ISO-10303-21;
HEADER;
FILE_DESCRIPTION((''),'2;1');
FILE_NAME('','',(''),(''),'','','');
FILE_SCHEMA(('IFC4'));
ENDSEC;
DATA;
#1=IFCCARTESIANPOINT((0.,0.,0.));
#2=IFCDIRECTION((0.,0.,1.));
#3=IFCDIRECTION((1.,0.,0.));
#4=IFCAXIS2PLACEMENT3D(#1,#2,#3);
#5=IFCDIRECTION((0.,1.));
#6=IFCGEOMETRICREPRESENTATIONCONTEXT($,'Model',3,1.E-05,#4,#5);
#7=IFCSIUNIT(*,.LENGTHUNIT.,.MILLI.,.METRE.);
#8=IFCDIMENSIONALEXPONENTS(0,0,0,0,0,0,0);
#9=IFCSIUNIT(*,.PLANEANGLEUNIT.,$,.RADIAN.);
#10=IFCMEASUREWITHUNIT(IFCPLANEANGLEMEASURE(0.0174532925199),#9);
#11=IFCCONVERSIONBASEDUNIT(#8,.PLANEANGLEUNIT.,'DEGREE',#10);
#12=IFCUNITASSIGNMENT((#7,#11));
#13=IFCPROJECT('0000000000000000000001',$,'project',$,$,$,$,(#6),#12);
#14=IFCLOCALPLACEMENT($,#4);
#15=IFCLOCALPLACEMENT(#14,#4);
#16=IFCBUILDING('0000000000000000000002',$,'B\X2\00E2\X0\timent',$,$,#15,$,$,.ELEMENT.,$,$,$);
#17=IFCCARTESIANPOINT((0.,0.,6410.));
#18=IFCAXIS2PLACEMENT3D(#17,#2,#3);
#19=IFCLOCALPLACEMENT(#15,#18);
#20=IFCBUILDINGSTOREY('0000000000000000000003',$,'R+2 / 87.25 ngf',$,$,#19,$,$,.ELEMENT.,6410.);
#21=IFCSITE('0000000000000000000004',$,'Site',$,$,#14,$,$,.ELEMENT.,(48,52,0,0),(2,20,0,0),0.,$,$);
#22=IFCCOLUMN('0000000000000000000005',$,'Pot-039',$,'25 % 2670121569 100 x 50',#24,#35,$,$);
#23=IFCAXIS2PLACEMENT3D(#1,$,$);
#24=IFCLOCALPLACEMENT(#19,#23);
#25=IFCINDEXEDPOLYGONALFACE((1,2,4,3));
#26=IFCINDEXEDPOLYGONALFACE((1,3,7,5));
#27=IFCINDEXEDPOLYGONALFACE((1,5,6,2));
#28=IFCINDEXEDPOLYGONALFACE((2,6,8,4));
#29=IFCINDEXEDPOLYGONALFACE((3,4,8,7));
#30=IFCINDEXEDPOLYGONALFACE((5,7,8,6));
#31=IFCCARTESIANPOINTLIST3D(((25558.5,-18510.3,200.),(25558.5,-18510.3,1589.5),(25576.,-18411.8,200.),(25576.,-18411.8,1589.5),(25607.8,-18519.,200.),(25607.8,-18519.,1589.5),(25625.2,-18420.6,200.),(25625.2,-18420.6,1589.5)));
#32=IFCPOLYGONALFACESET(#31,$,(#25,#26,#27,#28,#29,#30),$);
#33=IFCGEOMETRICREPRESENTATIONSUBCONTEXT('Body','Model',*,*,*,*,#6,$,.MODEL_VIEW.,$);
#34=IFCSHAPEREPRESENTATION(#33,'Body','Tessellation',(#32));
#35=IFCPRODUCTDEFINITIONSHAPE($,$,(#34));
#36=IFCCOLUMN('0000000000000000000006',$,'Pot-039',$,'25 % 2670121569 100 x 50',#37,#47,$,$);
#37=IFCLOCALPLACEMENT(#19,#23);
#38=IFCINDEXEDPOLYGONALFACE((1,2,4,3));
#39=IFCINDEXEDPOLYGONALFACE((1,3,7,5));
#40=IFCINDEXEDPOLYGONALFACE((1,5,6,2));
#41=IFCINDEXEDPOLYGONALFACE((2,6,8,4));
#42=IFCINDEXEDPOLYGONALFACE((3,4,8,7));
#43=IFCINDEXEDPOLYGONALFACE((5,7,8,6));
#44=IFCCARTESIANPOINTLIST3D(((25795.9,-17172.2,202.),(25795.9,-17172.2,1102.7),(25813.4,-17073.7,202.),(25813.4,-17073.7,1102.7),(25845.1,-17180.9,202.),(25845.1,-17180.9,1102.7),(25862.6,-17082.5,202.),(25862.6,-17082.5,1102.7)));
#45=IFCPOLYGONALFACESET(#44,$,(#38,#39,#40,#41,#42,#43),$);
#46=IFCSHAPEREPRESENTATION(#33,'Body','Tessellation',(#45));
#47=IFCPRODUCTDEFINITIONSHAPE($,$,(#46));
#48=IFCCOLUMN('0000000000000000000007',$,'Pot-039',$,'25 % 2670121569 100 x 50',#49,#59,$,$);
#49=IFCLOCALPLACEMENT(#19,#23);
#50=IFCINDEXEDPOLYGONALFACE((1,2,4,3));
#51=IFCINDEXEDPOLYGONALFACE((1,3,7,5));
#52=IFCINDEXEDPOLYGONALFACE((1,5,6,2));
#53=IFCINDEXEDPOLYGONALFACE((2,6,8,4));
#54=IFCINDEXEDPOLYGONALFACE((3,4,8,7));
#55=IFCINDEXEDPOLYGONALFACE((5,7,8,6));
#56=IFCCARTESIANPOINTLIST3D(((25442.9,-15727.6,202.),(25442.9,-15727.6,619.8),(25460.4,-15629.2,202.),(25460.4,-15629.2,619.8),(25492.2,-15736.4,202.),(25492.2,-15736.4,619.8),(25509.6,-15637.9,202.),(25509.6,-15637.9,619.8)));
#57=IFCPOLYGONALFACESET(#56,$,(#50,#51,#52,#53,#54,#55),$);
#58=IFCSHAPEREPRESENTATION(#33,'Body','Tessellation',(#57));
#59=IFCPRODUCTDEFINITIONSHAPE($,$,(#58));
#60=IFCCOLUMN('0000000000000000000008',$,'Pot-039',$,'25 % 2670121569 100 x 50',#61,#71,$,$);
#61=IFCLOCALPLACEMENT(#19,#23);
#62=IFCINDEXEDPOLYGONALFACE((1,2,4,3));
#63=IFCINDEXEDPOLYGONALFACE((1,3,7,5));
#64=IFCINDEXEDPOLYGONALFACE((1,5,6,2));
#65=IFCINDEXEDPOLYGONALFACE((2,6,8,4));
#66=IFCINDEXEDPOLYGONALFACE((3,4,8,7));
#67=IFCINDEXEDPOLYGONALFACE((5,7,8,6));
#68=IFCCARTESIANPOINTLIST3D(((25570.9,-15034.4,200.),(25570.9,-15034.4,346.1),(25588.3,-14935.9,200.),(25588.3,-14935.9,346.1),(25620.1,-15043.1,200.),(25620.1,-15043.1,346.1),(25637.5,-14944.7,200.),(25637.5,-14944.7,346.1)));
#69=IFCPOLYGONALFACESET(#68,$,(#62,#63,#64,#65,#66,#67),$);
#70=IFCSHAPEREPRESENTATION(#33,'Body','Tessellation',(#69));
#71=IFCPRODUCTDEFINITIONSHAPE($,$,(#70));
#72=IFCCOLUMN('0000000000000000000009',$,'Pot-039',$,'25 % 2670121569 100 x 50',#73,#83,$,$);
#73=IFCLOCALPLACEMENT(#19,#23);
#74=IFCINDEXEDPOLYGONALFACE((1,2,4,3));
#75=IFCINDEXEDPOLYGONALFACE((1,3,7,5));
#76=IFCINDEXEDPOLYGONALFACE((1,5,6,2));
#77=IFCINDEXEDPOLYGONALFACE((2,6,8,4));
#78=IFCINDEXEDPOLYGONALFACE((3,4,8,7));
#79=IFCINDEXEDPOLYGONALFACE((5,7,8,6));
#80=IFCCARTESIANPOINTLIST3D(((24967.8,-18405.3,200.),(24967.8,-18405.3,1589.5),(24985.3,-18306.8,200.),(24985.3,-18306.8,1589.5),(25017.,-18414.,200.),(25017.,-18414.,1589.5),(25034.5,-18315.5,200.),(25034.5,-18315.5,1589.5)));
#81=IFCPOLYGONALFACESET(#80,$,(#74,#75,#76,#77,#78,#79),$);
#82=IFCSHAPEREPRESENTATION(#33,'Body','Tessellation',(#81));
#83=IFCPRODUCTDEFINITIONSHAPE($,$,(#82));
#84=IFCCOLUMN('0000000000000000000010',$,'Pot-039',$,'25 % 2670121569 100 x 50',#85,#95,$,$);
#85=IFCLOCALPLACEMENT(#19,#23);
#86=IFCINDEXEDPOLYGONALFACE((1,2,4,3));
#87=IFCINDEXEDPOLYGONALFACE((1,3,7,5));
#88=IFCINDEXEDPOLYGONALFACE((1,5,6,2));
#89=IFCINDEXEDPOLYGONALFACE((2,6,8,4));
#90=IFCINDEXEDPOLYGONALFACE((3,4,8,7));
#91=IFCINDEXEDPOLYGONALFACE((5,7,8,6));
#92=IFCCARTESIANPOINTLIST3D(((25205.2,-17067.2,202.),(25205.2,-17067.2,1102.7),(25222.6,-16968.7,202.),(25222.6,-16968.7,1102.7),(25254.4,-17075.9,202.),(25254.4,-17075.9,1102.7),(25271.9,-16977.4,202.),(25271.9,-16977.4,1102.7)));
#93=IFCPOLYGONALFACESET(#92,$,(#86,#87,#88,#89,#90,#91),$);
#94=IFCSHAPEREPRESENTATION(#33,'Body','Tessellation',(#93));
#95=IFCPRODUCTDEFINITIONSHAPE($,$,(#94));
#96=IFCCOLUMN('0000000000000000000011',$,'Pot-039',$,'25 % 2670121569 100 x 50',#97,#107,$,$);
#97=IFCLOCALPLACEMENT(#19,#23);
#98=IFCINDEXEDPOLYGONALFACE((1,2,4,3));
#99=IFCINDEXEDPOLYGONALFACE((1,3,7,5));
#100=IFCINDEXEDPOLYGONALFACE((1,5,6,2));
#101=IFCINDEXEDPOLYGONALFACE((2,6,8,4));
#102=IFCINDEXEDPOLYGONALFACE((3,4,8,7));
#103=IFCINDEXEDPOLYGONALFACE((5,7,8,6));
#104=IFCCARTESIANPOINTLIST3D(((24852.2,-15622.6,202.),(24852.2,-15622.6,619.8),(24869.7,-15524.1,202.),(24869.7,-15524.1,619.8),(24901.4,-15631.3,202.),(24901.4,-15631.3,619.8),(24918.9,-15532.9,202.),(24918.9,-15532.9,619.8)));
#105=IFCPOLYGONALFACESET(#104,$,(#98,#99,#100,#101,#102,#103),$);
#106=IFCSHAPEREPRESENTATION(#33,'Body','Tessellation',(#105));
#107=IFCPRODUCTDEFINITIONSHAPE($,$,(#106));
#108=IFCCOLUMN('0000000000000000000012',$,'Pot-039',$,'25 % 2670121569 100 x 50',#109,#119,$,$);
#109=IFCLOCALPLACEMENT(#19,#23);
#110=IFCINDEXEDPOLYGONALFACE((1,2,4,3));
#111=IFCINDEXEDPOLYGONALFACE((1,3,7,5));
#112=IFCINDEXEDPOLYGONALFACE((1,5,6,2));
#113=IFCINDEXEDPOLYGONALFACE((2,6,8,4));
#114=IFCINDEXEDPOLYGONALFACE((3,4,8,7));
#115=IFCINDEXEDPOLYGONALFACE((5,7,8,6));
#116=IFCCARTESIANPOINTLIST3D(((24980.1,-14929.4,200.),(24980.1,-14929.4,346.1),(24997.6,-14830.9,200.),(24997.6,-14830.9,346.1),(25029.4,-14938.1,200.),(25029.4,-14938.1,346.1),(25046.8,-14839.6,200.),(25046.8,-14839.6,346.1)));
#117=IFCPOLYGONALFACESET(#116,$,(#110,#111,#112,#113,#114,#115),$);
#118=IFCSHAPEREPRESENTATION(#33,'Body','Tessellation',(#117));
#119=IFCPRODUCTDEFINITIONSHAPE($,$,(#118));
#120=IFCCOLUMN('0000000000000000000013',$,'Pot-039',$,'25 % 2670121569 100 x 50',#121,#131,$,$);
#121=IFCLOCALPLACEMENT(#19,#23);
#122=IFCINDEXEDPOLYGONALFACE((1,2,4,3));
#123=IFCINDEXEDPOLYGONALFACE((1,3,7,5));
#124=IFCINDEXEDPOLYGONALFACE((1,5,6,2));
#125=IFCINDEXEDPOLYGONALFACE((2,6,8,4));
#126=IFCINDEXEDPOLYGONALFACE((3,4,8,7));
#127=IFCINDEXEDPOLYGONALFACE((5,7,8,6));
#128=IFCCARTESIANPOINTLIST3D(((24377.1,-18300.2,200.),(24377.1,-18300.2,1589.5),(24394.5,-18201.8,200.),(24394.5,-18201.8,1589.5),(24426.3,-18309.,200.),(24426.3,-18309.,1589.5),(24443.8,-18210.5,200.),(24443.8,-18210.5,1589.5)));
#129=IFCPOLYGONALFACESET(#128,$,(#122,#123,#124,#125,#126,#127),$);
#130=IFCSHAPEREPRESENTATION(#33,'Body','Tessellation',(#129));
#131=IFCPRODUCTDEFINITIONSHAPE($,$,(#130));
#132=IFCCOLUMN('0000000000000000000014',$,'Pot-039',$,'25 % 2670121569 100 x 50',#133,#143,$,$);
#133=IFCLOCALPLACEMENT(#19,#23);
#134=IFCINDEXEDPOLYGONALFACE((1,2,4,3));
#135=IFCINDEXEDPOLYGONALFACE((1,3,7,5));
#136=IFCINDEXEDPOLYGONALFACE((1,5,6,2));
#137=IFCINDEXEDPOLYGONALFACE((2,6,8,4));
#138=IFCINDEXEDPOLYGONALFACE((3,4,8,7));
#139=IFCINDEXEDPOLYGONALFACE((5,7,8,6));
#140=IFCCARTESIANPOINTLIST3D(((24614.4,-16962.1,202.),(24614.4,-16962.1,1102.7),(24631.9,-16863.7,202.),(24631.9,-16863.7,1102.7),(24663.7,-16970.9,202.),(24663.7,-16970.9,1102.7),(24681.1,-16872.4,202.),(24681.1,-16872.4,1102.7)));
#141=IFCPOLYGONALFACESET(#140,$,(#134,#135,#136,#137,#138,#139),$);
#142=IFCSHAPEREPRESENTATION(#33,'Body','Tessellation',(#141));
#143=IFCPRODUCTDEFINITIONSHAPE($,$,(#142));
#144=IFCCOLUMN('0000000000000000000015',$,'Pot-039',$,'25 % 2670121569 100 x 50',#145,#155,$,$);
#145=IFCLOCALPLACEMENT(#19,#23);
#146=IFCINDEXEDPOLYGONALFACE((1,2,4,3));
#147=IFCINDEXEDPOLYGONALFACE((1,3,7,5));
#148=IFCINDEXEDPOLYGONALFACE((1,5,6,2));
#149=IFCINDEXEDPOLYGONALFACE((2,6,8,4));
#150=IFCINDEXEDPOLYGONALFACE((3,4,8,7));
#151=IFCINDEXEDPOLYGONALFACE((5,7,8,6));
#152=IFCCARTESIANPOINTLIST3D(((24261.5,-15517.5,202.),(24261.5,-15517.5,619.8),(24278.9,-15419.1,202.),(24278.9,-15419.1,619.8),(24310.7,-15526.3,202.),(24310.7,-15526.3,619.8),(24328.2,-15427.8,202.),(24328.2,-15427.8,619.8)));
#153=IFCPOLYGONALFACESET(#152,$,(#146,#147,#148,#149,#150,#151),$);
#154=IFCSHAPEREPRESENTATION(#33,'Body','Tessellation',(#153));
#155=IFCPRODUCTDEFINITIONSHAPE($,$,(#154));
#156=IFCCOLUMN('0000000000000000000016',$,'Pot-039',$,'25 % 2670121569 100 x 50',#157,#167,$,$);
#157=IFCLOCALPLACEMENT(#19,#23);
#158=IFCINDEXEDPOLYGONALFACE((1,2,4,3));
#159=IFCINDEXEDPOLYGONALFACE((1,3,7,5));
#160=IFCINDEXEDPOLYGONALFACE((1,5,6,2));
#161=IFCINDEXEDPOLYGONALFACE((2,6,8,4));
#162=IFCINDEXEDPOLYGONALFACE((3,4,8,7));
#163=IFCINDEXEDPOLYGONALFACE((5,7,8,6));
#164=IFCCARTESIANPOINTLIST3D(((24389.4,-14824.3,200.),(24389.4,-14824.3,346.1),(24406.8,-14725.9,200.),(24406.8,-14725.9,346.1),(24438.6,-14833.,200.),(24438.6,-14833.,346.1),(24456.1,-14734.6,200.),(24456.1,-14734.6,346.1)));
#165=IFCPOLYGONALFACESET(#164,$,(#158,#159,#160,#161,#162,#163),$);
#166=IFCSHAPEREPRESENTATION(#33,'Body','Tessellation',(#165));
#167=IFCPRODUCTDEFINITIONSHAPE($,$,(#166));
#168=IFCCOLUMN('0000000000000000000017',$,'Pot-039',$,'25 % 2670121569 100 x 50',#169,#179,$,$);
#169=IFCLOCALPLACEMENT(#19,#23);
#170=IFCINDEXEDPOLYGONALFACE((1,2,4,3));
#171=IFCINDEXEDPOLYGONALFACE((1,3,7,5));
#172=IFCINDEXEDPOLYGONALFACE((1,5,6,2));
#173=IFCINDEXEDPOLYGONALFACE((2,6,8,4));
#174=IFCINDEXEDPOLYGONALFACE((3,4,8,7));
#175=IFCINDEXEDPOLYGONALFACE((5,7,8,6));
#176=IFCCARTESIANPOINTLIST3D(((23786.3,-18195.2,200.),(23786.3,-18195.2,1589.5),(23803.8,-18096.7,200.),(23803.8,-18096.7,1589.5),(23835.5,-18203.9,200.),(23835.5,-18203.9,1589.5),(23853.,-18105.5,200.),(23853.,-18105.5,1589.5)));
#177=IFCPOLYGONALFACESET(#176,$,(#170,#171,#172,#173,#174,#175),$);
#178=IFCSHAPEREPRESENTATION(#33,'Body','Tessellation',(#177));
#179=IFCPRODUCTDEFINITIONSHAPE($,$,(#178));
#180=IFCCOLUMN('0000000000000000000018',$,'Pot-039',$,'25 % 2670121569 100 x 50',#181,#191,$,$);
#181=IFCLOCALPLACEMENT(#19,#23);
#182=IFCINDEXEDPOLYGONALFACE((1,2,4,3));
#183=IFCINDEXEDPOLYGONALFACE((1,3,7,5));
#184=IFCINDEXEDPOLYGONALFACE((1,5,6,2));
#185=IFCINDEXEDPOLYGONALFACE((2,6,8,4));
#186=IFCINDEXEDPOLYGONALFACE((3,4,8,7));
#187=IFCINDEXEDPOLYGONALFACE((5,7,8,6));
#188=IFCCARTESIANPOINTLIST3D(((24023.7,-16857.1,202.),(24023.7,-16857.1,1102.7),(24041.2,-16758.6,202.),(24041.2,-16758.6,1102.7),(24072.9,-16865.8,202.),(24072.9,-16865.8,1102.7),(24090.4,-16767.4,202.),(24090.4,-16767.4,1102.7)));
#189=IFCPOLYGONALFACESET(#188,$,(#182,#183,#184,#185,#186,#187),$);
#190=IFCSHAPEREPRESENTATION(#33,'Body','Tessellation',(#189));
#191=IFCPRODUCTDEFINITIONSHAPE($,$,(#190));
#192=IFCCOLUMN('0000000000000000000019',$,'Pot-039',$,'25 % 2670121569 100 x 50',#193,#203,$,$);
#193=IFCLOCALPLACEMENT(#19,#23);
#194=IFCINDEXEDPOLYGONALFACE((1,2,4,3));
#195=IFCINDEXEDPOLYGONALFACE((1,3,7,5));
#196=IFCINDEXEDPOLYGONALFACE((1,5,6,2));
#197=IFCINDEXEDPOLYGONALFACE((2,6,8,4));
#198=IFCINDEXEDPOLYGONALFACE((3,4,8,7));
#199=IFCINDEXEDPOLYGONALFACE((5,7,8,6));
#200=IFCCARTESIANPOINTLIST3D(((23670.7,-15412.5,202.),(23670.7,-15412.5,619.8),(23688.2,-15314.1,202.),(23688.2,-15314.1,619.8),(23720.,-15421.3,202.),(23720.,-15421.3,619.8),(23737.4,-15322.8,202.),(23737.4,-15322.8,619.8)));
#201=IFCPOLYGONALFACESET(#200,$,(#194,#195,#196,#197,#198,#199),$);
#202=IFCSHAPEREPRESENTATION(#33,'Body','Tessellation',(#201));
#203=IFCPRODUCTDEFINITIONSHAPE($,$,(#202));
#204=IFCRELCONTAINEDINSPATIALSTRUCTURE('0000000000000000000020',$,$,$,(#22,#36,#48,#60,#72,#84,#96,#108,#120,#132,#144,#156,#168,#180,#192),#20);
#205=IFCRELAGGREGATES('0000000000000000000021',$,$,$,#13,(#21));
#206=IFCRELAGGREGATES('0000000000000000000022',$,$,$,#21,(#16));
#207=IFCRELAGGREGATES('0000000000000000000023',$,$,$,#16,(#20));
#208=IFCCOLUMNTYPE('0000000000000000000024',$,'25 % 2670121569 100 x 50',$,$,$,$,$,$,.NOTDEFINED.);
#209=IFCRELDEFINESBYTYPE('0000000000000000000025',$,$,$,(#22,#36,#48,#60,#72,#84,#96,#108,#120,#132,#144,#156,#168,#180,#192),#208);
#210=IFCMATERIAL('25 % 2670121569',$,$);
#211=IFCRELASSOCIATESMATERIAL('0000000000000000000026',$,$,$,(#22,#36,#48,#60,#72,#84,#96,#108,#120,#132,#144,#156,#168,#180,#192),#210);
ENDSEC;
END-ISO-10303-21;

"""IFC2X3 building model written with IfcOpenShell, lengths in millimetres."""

from ifc_helpers import new_model, entity, si_unit, converted_unit, direction, frame, origin_with_axes, origin_2d_with_axis, place, context, subcontext, project, spatial, rectangle, extrude, material, type_object, element, save


model = new_model("IFC2X3")

# Units and contexts
model_context = context("Model", 3, precision=1e-05, world=origin_with_axes(), true_north=direction((0.0, 1.0)))
body_context = subcontext(model_context, "Body", "Model", "MODEL_VIEW")
ifc_project = project(units=[si_unit("LENGTHUNIT", "METRE", prefix="MILLI"), converted_unit("PLANEANGLEUNIT", "DEGREE", entity("IfcPlaneAngleMeasure", 0.0174532925199), si_unit("PLANEANGLEUNIT", "RADIAN"), dimensions=[0, 0, 0, 0, 0, 0, 0])], contexts=[model_context])

# Site, building, storey
site_placement = place(None, origin_with_axes())
site = spatial("IfcSite", under=ifc_project, at=site_placement, Name="Site", CompositionType="ELEMENT", RefLatitude=(48, 52, 0, 0), RefLongitude=(2, 20, 0, 0), RefElevation=0.0)
building_placement = place(site_placement, origin_with_axes())
building = spatial("IfcBuilding", under=site, at=building_placement, Name="Bâtiment", CompositionType="ELEMENT")
storey_placement = place(building_placement, frame((0.0, 0.0, 6410.0), z_axis=(0.0, 0.0, 1.0), x_axis=(1.0, 0.0, 0.0)))
storey = spatial("IfcBuildingStorey", under=building, at=storey_placement, Name="R+2 / 87.25 ngf", CompositionType="ELEMENT", Elevation=6410.0)

# Columns
ifc_material = material(Name="25 % 2670121569")
column_type = type_object("IfcColumnType", Name="25 % 2670121569 100 x 50", PredefinedType="NOTDEFINED")
column_1_placement = place(storey_placement, frame((25591.9, -18465.4, 200.0), z_axis=(0.0, 0.0, 1.0), x_axis=(0.17478, 0.984607, 0.0)))
element("IfcColumn", 1, at=column_1_placement, inside=storey, type_object=column_type, material=ifc_material, Name="Pot-039", ObjectType="25 % 2670121569 100 x 50", context=body_context, shape_type="SweptSolid", body=[
    extrude(rectangle(XDim=100.0, YDim=50.0, at=origin_2d_with_axis()), origin_with_axes(), (0.0, 0.0, 1.0), 1389.5),
])
column_2_placement = place(storey_placement, frame((25829.2, -17127.3, 202.0), z_axis=(0.0, 0.0, 1.0), x_axis=(0.17478, 0.984607, 0.0)))
element("IfcColumn", 2, at=column_2_placement, inside=storey, type_object=column_type, material=ifc_material, Name="Pot-039", ObjectType="25 % 2670121569 100 x 50", context=body_context, shape_type="SweptSolid", body=[
    extrude(rectangle(XDim=100.0, YDim=50.0, at=origin_2d_with_axis()), origin_with_axes(), (0.0, 0.0, 1.0), 900.7),
])
column_3_placement = place(storey_placement, frame((25476.3, -15682.8, 202.0), z_axis=(0.0, 0.0, 1.0), x_axis=(0.17478, 0.984607, 0.0)))
element("IfcColumn", 3, at=column_3_placement, inside=storey, type_object=column_type, material=ifc_material, Name="Pot-039", ObjectType="25 % 2670121569 100 x 50", context=body_context, shape_type="SweptSolid", body=[
    extrude(rectangle(XDim=100.0, YDim=50.0, at=origin_2d_with_axis()), origin_with_axes(), (0.0, 0.0, 1.0), 417.8),
])
column_4_placement = place(storey_placement, frame((25604.2, -14989.5, 200.0), z_axis=(0.0, 0.0, 1.0), x_axis=(0.174407, 0.984674, 0.0)))
element("IfcColumn", 4, at=column_4_placement, inside=storey, type_object=column_type, material=ifc_material, Name="Pot-039", ObjectType="25 % 2670121569 100 x 50", context=body_context, shape_type="SweptSolid", body=[
    extrude(rectangle(XDim=100.0, YDim=50.0, at=origin_2d_with_axis()), origin_with_axes(), (0.0, 0.0, 1.0), 146.1),
])
column_5_placement = place(storey_placement, frame((25001.1, -18360.4, 200.0), z_axis=(0.0, 0.0, 1.0), x_axis=(0.17478, 0.984607, 0.0)))
element("IfcColumn", 5, at=column_5_placement, inside=storey, type_object=column_type, material=ifc_material, Name="Pot-039", ObjectType="25 % 2670121569 100 x 50", context=body_context, shape_type="SweptSolid", body=[
    extrude(rectangle(XDim=100.0, YDim=50.0, at=origin_2d_with_axis()), origin_with_axes(), (0.0, 0.0, 1.0), 1389.5),
])
column_6_placement = place(storey_placement, frame((25238.5, -17022.3, 202.0), z_axis=(0.0, 0.0, 1.0), x_axis=(0.17478, 0.984607, 0.0)))
element("IfcColumn", 6, at=column_6_placement, inside=storey, type_object=column_type, material=ifc_material, Name="Pot-039", ObjectType="25 % 2670121569 100 x 50", context=body_context, shape_type="SweptSolid", body=[
    extrude(rectangle(XDim=100.0, YDim=50.0, at=origin_2d_with_axis()), origin_with_axes(), (0.0, 0.0, 1.0), 900.7),
])
column_7_placement = place(storey_placement, frame((24885.5, -15577.7, 202.0), z_axis=(0.0, 0.0, 1.0), x_axis=(0.17478, 0.984607, 0.0)))
element("IfcColumn", 7, at=column_7_placement, inside=storey, type_object=column_type, material=ifc_material, Name="Pot-039", ObjectType="25 % 2670121569 100 x 50", context=body_context, shape_type="SweptSolid", body=[
    extrude(rectangle(XDim=100.0, YDim=50.0, at=origin_2d_with_axis()), origin_with_axes(), (0.0, 0.0, 1.0), 417.8),
])
column_8_placement = place(storey_placement, frame((25013.5, -14884.5, 200.0), z_axis=(0.0, 0.0, 1.0), x_axis=(0.174407, 0.984674, 0.0)))
element("IfcColumn", 8, at=column_8_placement, inside=storey, type_object=column_type, material=ifc_material, Name="Pot-039", ObjectType="25 % 2670121569 100 x 50", context=body_context, shape_type="SweptSolid", body=[
    extrude(rectangle(XDim=100.0, YDim=50.0, at=origin_2d_with_axis()), origin_with_axes(), (0.0, 0.0, 1.0), 146.1),
])
column_9_placement = place(storey_placement, frame((24410.4, -18255.4, 200.0), z_axis=(0.0, 0.0, 1.0), x_axis=(0.17478, 0.984607, 0.0)))
element("IfcColumn", 9, at=column_9_placement, inside=storey, type_object=column_type, material=ifc_material, Name="Pot-039", ObjectType="25 % 2670121569 100 x 50", context=body_context, shape_type="SweptSolid", body=[
    extrude(rectangle(XDim=100.0, YDim=50.0, at=origin_2d_with_axis()), origin_with_axes(), (0.0, 0.0, 1.0), 1389.5),
])
column_10_placement = place(storey_placement, frame((24647.8, -16917.3, 202.0), z_axis=(0.0, 0.0, 1.0), x_axis=(0.17478, 0.984607, 0.0)))
element("IfcColumn", 10, at=column_10_placement, inside=storey, type_object=column_type, material=ifc_material, Name="Pot-039", ObjectType="25 % 2670121569 100 x 50", context=body_context, shape_type="SweptSolid", body=[
    extrude(rectangle(XDim=100.0, YDim=50.0, at=origin_2d_with_axis()), origin_with_axes(), (0.0, 0.0, 1.0), 900.7),
])
column_11_placement = place(storey_placement, frame((24294.8, -15472.7, 202.0), z_axis=(0.0, 0.0, 1.0), x_axis=(0.17478, 0.984607, 0.0)))
element("IfcColumn", 11, at=column_11_placement, inside=storey, type_object=column_type, material=ifc_material, Name="Pot-039", ObjectType="25 % 2670121569 100 x 50", context=body_context, shape_type="SweptSolid", body=[
    extrude(rectangle(XDim=100.0, YDim=50.0, at=origin_2d_with_axis()), origin_with_axes(), (0.0, 0.0, 1.0), 417.8),
])
column_12_placement = place(storey_placement, frame((24422.7, -14779.5, 200.0), z_axis=(0.0, 0.0, 1.0), x_axis=(0.174407, 0.984674, 0.0)))
element("IfcColumn", 12, at=column_12_placement, inside=storey, type_object=column_type, material=ifc_material, Name="Pot-039", ObjectType="25 % 2670121569 100 x 50", context=body_context, shape_type="SweptSolid", body=[
    extrude(rectangle(XDim=100.0, YDim=50.0, at=origin_2d_with_axis()), origin_with_axes(), (0.0, 0.0, 1.0), 146.1),
])
column_13_placement = place(storey_placement, frame((23819.7, -18150.3, 200.0), z_axis=(0.0, 0.0, 1.0), x_axis=(0.17478, 0.984607, 0.0)))
element("IfcColumn", 13, at=column_13_placement, inside=storey, type_object=column_type, material=ifc_material, Name="Pot-039", ObjectType="25 % 2670121569 100 x 50", context=body_context, shape_type="SweptSolid", body=[
    extrude(rectangle(XDim=100.0, YDim=50.0, at=origin_2d_with_axis()), origin_with_axes(), (0.0, 0.0, 1.0), 1389.5),
])
column_14_placement = place(storey_placement, frame((24057.0, -16812.2, 202.0), z_axis=(0.0, 0.0, 1.0), x_axis=(0.17478, 0.984607, 0.0)))
element("IfcColumn", 14, at=column_14_placement, inside=storey, type_object=column_type, material=ifc_material, Name="Pot-039", ObjectType="25 % 2670121569 100 x 50", context=body_context, shape_type="SweptSolid", body=[
    extrude(rectangle(XDim=100.0, YDim=50.0, at=origin_2d_with_axis()), origin_with_axes(), (0.0, 0.0, 1.0), 900.7),
])
column_15_placement = place(storey_placement, frame((23704.1, -15367.7, 202.0), z_axis=(0.0, 0.0, 1.0), x_axis=(0.17478, 0.984607, 0.0)))
element("IfcColumn", 15, at=column_15_placement, inside=storey, type_object=column_type, material=ifc_material, Name="Pot-039", ObjectType="25 % 2670121569 100 x 50", context=body_context, shape_type="SweptSolid", body=[
    extrude(rectangle(XDim=100.0, YDim=50.0, at=origin_2d_with_axis()), origin_with_axes(), (0.0, 0.0, 1.0), 417.8),
])

save(model, "model.ifc")
